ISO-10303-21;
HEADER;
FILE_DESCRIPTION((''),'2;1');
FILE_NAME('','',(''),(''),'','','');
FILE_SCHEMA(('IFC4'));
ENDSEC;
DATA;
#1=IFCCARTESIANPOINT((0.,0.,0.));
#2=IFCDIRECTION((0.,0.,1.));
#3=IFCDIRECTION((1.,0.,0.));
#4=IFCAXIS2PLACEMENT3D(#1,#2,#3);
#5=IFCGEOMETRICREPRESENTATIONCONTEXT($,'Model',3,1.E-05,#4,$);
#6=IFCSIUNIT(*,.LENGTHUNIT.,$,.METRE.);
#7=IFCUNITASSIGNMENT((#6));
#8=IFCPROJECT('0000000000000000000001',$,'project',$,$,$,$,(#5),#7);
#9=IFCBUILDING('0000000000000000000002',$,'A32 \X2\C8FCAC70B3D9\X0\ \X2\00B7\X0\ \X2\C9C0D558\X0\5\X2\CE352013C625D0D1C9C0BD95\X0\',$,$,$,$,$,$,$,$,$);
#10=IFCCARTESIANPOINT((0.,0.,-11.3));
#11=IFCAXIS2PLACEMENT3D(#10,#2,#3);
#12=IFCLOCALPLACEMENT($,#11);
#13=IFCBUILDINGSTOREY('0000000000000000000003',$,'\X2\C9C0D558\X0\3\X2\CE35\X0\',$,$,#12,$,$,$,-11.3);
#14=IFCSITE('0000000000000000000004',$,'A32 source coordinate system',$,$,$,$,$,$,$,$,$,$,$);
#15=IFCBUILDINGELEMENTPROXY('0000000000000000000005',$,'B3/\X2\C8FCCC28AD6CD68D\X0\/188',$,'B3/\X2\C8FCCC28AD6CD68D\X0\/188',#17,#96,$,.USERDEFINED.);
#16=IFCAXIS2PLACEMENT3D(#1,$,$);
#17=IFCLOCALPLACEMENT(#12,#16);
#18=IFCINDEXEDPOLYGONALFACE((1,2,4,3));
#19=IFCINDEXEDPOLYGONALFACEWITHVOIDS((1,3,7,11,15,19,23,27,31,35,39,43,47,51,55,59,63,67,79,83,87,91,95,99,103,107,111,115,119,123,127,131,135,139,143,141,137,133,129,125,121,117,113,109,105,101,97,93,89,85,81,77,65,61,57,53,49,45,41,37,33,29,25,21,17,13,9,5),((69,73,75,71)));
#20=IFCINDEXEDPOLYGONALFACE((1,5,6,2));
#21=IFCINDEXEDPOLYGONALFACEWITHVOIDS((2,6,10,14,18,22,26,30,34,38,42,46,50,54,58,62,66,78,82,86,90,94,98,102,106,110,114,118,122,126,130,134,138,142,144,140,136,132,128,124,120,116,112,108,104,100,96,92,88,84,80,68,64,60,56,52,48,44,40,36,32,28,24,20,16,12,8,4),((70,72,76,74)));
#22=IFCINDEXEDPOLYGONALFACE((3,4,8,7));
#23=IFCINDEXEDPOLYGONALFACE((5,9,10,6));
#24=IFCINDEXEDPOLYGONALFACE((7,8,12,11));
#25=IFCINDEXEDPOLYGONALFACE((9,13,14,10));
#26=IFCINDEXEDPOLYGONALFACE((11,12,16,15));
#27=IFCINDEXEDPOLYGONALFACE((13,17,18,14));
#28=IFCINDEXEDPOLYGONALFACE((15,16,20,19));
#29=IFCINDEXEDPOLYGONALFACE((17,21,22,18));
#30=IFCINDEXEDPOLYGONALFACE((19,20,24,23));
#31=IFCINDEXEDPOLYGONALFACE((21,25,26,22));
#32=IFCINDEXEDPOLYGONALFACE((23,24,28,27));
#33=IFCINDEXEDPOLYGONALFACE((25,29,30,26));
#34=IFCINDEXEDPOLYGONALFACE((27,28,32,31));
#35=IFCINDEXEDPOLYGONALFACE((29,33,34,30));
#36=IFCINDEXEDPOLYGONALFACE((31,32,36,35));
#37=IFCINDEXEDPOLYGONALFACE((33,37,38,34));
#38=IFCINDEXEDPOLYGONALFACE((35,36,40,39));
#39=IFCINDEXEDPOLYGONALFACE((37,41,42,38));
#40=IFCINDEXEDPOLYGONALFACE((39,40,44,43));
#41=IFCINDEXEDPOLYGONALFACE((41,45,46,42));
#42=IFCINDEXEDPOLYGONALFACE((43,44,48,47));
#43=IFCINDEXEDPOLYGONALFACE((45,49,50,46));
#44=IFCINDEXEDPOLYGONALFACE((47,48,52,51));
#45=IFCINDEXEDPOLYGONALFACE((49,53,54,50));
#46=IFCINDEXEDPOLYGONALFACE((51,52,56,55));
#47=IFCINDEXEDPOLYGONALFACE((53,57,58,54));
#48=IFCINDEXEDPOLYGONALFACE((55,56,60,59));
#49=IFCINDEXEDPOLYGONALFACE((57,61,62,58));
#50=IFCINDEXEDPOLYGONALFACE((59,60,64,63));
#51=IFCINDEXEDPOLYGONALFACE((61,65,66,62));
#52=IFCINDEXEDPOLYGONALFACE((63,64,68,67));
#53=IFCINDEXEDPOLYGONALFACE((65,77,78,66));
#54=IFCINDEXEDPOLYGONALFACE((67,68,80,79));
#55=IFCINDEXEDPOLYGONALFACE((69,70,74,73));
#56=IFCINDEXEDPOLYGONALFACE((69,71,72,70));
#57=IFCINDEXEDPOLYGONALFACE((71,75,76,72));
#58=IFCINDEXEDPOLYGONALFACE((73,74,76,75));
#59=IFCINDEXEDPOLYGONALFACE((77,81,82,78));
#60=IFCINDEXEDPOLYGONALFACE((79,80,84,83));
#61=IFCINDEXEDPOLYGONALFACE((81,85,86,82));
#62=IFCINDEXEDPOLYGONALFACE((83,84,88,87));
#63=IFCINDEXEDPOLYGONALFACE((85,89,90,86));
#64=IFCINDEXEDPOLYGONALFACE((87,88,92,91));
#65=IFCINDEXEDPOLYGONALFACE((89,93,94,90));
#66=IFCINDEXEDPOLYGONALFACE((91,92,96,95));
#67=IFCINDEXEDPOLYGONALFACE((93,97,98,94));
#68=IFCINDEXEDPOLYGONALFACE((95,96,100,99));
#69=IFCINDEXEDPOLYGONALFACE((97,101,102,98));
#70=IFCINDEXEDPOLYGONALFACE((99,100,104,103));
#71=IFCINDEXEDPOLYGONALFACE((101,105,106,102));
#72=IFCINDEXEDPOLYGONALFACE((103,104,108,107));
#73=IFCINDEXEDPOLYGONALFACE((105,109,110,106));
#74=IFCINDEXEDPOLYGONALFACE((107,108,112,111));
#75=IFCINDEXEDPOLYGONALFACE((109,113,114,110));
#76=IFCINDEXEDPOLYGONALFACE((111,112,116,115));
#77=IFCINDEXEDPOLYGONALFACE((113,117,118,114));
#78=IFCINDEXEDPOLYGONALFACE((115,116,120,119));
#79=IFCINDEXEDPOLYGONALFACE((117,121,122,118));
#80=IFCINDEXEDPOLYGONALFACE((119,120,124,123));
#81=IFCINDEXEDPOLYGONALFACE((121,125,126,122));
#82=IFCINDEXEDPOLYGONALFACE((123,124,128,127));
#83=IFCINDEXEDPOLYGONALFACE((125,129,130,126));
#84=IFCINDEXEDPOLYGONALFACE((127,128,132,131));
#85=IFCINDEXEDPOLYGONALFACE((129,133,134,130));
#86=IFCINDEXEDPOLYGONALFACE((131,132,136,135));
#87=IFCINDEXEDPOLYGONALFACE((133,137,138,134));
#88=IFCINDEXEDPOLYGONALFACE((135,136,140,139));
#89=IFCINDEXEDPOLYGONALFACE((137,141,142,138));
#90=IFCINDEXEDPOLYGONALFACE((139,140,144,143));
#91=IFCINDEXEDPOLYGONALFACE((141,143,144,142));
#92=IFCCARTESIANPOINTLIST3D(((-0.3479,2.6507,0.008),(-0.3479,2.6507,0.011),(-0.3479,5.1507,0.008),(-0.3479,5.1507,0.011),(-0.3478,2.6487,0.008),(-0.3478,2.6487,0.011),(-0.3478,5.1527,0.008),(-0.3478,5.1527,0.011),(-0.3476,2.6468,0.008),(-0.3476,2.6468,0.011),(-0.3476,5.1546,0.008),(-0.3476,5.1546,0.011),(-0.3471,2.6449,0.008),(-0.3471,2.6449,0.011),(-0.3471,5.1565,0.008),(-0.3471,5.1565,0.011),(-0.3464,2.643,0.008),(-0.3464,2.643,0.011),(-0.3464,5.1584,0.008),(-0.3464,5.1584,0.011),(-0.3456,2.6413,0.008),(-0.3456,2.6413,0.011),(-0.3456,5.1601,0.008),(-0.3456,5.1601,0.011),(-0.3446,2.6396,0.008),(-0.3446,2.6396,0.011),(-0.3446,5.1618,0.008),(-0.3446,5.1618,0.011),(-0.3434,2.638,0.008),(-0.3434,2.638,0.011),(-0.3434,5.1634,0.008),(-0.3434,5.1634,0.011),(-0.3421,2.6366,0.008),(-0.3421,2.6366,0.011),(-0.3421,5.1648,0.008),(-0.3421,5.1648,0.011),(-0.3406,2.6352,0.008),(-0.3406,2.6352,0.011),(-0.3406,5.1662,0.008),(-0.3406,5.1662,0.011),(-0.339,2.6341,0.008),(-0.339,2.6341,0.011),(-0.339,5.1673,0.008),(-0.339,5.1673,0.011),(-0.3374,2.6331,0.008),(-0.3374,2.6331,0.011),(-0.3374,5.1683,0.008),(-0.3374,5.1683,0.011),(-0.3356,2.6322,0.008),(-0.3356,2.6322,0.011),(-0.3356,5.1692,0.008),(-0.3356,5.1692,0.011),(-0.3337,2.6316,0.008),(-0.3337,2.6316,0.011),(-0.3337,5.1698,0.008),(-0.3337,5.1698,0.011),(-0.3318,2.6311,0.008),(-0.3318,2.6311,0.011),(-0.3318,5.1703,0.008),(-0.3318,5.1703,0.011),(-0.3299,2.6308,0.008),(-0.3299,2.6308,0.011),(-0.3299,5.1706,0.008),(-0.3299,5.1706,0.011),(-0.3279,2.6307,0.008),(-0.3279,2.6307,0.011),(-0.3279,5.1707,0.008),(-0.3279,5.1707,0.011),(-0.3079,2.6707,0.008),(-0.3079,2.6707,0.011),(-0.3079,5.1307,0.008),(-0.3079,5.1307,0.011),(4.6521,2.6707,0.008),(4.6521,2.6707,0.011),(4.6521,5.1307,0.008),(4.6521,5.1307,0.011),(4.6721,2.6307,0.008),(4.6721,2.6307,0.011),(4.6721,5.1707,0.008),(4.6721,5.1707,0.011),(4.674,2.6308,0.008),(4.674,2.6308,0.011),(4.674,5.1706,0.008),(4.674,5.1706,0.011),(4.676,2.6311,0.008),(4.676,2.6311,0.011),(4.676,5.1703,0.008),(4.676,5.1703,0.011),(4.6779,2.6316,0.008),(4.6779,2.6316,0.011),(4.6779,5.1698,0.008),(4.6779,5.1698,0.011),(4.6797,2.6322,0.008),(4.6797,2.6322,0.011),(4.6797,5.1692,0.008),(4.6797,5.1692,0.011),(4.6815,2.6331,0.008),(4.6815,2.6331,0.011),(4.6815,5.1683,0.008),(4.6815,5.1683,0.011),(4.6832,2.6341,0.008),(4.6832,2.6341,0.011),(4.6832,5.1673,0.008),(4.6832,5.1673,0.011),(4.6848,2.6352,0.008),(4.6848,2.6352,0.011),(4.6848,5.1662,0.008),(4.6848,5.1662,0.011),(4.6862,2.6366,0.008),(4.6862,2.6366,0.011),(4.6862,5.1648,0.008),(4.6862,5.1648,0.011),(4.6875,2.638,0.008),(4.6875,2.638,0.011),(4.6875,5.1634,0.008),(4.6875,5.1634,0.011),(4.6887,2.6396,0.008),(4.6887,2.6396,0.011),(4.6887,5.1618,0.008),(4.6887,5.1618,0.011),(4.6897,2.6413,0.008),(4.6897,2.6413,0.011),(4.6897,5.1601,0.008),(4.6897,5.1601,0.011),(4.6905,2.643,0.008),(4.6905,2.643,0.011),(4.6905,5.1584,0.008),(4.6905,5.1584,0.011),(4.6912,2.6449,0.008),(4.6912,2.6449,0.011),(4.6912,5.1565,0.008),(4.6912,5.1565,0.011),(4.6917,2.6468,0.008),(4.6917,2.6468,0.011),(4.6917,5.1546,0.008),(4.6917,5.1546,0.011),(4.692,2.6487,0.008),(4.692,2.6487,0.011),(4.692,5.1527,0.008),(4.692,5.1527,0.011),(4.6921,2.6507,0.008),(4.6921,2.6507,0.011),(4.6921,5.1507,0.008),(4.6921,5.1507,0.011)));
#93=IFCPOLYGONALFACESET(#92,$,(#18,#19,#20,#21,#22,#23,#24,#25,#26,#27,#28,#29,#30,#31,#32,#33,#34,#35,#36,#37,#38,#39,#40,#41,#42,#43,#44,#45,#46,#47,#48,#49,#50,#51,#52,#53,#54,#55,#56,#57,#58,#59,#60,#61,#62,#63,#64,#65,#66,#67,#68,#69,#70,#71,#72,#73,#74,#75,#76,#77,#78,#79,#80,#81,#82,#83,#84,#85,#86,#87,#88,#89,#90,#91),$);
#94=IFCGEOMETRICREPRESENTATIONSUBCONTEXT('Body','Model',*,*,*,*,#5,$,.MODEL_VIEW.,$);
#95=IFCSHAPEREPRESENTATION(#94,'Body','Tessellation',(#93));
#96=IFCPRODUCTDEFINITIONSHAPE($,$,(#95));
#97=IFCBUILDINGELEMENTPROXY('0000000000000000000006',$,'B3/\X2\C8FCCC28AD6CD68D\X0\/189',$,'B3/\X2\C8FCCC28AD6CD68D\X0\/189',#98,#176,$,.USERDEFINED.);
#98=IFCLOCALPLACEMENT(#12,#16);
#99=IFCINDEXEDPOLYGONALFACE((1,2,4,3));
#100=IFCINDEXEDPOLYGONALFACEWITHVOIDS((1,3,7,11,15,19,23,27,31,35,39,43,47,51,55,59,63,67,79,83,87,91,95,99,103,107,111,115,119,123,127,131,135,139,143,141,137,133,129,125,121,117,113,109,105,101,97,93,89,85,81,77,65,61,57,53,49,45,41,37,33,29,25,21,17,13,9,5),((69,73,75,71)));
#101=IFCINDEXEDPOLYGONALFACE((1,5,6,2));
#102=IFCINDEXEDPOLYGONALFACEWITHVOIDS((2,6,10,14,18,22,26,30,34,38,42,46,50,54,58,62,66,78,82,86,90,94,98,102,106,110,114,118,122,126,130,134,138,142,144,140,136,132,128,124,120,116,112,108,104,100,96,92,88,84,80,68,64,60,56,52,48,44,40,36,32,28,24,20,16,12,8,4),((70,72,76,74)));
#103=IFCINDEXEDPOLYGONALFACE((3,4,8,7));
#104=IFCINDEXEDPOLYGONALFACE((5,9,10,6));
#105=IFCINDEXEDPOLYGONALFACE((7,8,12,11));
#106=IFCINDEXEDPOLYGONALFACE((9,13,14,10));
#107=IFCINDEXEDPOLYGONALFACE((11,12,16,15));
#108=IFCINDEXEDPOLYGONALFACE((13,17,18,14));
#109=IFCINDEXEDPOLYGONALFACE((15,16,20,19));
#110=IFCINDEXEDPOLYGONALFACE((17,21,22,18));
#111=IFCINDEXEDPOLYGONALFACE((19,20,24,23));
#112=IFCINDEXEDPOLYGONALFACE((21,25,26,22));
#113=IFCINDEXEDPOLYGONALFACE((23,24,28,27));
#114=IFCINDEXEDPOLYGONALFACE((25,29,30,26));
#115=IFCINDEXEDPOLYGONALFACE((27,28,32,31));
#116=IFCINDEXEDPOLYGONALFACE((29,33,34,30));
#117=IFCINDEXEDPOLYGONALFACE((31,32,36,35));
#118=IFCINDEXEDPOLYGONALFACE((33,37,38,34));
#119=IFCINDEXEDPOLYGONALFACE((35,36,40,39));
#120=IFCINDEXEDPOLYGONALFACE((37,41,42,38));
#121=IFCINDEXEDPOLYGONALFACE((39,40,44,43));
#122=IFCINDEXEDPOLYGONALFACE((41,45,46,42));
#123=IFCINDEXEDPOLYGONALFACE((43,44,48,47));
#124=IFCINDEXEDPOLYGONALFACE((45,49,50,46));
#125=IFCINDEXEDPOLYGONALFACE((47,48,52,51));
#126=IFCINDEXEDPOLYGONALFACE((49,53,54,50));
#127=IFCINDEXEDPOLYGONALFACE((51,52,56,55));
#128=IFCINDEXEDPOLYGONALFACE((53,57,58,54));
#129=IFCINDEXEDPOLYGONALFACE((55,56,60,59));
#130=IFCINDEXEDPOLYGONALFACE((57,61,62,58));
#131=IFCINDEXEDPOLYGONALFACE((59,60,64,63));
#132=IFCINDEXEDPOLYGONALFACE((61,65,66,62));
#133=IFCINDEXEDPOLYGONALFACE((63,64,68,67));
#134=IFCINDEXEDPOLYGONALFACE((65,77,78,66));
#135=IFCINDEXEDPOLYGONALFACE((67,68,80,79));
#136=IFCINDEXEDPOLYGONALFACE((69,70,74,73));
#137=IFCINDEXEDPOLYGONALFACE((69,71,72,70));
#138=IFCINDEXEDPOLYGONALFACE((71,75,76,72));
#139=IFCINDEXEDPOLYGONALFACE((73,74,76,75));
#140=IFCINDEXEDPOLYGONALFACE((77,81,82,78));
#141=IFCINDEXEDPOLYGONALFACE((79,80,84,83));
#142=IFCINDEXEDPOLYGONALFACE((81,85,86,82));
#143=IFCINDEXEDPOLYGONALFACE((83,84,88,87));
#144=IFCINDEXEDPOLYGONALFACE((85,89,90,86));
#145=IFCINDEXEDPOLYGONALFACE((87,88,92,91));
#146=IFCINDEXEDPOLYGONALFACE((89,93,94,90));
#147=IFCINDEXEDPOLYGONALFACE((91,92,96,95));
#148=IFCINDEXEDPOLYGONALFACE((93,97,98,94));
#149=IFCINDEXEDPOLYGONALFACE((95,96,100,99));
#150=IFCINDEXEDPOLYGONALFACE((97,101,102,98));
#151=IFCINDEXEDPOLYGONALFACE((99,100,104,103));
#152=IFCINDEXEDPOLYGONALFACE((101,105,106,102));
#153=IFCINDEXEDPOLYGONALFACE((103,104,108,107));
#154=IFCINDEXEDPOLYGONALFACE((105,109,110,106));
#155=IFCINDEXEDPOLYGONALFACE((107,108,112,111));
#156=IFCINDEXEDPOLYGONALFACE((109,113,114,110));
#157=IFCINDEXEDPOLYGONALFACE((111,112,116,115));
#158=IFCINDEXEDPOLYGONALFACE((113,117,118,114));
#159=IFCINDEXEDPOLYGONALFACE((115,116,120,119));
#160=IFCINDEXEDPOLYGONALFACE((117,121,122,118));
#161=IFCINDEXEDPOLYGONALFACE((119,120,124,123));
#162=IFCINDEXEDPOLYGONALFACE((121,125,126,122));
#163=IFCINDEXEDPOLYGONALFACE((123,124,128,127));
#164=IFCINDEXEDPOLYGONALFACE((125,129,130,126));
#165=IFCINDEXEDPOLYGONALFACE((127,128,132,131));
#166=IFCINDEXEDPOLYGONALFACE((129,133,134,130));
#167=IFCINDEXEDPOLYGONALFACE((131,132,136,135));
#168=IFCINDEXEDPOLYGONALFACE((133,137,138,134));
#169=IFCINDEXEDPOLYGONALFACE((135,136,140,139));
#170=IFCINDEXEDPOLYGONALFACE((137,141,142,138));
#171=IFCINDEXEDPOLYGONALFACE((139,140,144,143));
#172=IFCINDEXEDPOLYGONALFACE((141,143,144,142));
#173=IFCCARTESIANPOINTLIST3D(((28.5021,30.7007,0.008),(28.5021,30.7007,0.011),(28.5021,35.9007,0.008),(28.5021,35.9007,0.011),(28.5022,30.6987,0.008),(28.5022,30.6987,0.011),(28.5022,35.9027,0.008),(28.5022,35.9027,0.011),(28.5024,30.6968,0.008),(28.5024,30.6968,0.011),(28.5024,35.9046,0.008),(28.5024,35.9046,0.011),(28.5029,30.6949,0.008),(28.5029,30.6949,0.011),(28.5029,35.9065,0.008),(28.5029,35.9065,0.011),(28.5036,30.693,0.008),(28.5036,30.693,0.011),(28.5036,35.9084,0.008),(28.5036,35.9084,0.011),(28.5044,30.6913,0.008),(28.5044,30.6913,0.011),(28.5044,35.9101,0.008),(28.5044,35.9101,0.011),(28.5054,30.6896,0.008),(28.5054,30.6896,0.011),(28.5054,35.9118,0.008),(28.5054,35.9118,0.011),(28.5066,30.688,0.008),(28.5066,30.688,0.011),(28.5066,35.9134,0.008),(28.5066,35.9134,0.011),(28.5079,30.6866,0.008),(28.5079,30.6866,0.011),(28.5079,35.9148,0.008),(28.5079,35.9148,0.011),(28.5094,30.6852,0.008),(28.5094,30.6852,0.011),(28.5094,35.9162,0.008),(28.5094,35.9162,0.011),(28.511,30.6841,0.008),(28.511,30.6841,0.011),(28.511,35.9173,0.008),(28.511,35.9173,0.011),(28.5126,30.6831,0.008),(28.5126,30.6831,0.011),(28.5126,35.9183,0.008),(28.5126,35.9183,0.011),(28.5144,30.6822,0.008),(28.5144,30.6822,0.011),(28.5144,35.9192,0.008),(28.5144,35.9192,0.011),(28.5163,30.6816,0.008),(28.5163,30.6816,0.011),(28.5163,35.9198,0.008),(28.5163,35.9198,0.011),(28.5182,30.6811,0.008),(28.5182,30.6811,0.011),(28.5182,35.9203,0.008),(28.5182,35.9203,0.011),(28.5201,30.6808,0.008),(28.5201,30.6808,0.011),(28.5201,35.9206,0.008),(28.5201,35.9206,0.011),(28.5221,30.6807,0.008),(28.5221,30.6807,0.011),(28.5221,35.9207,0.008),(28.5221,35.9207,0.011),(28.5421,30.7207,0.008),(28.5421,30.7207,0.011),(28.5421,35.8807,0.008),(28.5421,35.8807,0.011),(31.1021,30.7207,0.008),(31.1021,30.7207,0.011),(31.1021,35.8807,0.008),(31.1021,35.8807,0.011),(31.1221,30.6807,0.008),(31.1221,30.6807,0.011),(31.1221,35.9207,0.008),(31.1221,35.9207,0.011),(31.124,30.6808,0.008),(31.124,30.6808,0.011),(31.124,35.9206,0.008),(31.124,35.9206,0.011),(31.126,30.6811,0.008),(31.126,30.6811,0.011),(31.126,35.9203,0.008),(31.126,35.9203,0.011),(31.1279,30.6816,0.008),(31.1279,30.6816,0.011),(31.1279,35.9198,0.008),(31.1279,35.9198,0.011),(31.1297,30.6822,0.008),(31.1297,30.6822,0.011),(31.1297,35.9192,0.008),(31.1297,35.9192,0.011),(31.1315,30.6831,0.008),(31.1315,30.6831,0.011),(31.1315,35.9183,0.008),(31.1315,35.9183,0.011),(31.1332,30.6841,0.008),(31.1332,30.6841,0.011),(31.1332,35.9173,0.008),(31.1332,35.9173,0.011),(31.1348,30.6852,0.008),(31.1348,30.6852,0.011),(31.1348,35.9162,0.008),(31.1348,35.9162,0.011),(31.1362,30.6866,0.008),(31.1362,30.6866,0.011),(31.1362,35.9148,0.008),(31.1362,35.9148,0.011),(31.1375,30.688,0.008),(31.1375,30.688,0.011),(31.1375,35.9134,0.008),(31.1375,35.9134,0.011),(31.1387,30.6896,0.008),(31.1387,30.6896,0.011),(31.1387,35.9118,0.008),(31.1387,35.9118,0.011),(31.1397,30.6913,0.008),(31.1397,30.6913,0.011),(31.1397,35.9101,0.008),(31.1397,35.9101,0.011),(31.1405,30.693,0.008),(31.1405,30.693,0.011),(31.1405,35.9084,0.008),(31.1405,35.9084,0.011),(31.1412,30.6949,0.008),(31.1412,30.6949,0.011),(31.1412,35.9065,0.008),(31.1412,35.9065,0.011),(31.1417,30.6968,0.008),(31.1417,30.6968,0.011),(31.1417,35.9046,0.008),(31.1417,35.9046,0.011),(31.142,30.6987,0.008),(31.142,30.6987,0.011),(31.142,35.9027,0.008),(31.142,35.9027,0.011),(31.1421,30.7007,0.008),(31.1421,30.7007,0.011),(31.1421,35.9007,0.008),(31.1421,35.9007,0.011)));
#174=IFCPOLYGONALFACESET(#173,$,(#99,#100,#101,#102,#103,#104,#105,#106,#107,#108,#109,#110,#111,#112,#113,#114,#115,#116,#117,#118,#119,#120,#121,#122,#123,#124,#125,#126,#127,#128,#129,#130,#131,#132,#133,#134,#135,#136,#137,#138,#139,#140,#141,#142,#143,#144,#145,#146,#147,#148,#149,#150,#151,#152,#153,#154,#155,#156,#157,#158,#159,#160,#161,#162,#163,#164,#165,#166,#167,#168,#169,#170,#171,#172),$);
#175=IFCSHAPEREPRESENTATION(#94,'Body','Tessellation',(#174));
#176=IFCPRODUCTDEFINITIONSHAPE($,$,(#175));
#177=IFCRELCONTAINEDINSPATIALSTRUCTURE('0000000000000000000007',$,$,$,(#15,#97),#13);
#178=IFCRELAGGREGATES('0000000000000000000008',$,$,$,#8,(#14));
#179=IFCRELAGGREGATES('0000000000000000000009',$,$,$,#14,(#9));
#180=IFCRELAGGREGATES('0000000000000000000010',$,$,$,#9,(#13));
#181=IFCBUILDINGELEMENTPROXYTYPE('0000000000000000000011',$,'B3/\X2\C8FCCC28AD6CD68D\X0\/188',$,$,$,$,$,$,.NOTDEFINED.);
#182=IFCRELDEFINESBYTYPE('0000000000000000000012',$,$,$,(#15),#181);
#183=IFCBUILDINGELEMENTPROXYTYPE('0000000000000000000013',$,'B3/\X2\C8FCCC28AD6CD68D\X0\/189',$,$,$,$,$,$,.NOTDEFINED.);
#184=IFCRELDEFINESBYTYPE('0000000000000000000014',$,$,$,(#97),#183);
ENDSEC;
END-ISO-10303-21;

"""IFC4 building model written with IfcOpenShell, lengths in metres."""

from ifc_helpers import new_model, si_unit, frame, origin, origin_with_axes, place, context, subcontext, project, spatial, polyline, outline, extrude, source, transform, mapped, type_object, type_shapes, element, save


model = new_model("IFC4")

# Units and contexts
model_context = context("Model", 3, precision=1e-05, world=origin_with_axes())
body_context = subcontext(model_context, "Body", "Model", "MODEL_VIEW")
ifc_project = project(units=[si_unit("LENGTHUNIT", "METRE")], contexts=[model_context])

# Site, building, storey
site = spatial("IfcSite", under=ifc_project, Name="A32 source coordinate system")
building = spatial("IfcBuilding", under=site, Name="A32 주거동 · 지하5층–옥탑지붕")
storey_placement = place(None, frame((0.0, 0.0, -11.3), z_axis=(0.0, 0.0, 1.0), x_axis=(1.0, 0.0, 0.0)))
storey = spatial("IfcBuildingStorey", under=building, at=storey_placement, Name="지하3층", Elevation=-11.3)

# Building element proxies
building_element_proxy_type_1 = type_object("IfcBuildingElementProxyType", Name="B3/주차구획/188", PredefinedType="NOTDEFINED")
shared_shape_1 = source(origin(), body_context, "Body", "SweptSolid", [
    extrude(outline(polyline([(-0.3279, 2.6307), (-0.3299, 2.6308), (-0.3318, 2.6311), (-0.3337, 2.6316), (-0.3356, 2.6322), (-0.3374, 2.6331), (-0.339, 2.6341), (-0.3406, 2.6352), (-0.3421, 2.6366), (-0.3434, 2.638), (-0.3446, 2.6396), (-0.3456, 2.6413), (-0.3464, 2.643), (-0.3471, 2.6449), (-0.3476, 2.6468), (-0.3478, 2.6487), (-0.3479, 2.6507), (-0.3479, 5.1507), (-0.3478, 5.1527), (-0.3476, 5.1546), (-0.3471, 5.1565), (-0.3464, 5.1584), (-0.3456, 5.1601), (-0.3446, 5.1618), (-0.3434, 5.1634), (-0.3421, 5.1648), (-0.3406, 5.1662), (-0.339, 5.1673), (-0.3374, 5.1683), (-0.3356, 5.1692), (-0.3337, 5.1698), (-0.3318, 5.1703), (-0.3299, 5.1706), (-0.3279, 5.1707), (4.6721, 5.1707), (4.674, 5.1706), (4.676, 5.1703), (4.6779, 5.1698), (4.6797, 5.1692), (4.6815, 5.1683), (4.6832, 5.1673), (4.6848, 5.1662), (4.6862, 5.1648), (4.6875, 5.1634), (4.6887, 5.1618), (4.6897, 5.1601), (4.6905, 5.1584), (4.6912, 5.1565), (4.6917, 5.1546), (4.692, 5.1527), (4.6921, 5.1507), (4.6921, 2.6507), (4.692, 2.6487), (4.6917, 2.6468), (4.6912, 2.6449), (4.6905, 2.643), (4.6897, 2.6413), (4.6887, 2.6396), (4.6875, 2.638), (4.6862, 2.6366), (4.6848, 2.6352), (4.6832, 2.6341), (4.6815, 2.6331), (4.6797, 2.6322), (4.6779, 2.6316), (4.676, 2.6311), (4.674, 2.6308), (4.6721, 2.6307), (-0.3279, 2.6307)]), holes=[polyline([(-0.3079, 2.6707), (4.6521, 2.6707), (4.6521, 5.1307), (-0.3079, 5.1307), (-0.3079, 2.6707)])]), frame((0.0, 0.0, 0.008)), (0.0, 0.0, 1.0), 0.003),
])
type_shapes(building_element_proxy_type_1, [shared_shape_1])
proxy_1_placement = place(storey_placement, origin_with_axes())
element("IfcBuildingElementProxy", 1, at=proxy_1_placement, inside=storey, type_object=building_element_proxy_type_1, Name="B3/주차구획/188", ObjectType="B3/주차구획/188", PredefinedType="USERDEFINED", context=body_context, shape_type="MappedRepresentation", body=[
    mapped(shared_shape_1, transform((0.0, 0.0, 0.0), scale=1.0)),
])
building_element_proxy_type_2 = type_object("IfcBuildingElementProxyType", Name="B3/주차구획/189", PredefinedType="NOTDEFINED")
shared_shape_2 = source(origin(), body_context, "Body", "SweptSolid", [
    extrude(outline(polyline([(28.5021, 35.9007), (28.5022, 35.9027), (28.5024, 35.9046), (28.5029, 35.9065), (28.5036, 35.9084), (28.5044, 35.9101), (28.5054, 35.9118), (28.5066, 35.9134), (28.5079, 35.9148), (28.5094, 35.9162), (28.511, 35.9173), (28.5126, 35.9183), (28.5144, 35.9192), (28.5163, 35.9198), (28.5182, 35.9203), (28.5201, 35.9206), (28.5221, 35.9207), (31.1221, 35.9207), (31.124, 35.9206), (31.126, 35.9203), (31.1279, 35.9198), (31.1297, 35.9192), (31.1315, 35.9183), (31.1332, 35.9173), (31.1348, 35.9162), (31.1362, 35.9148), (31.1375, 35.9134), (31.1387, 35.9118), (31.1397, 35.9101), (31.1405, 35.9084), (31.1412, 35.9065), (31.1417, 35.9046), (31.142, 35.9027), (31.1421, 35.9007), (31.1421, 30.7007), (31.142, 30.6987), (31.1417, 30.6968), (31.1412, 30.6949), (31.1405, 30.693), (31.1397, 30.6913), (31.1387, 30.6896), (31.1375, 30.688), (31.1362, 30.6866), (31.1348, 30.6852), (31.1332, 30.6841), (31.1315, 30.6831), (31.1297, 30.6822), (31.1279, 30.6816), (31.126, 30.6811), (31.124, 30.6808), (31.1221, 30.6807), (28.5221, 30.6807), (28.5201, 30.6808), (28.5182, 30.6811), (28.5163, 30.6816), (28.5144, 30.6822), (28.5126, 30.6831), (28.511, 30.6841), (28.5094, 30.6852), (28.5079, 30.6866), (28.5066, 30.688), (28.5054, 30.6896), (28.5044, 30.6913), (28.5036, 30.693), (28.5029, 30.6949), (28.5024, 30.6968), (28.5022, 30.6987), (28.5021, 30.7007), (28.5021, 35.9007)]), holes=[polyline([(28.5421, 35.8807), (28.5421, 30.7207), (31.1021, 30.7207), (31.1021, 35.8807), (28.5421, 35.8807)])]), frame((0.0, 0.0, 0.008)), (0.0, 0.0, 1.0), 0.003),
])
type_shapes(building_element_proxy_type_2, [shared_shape_2])
proxy_2_placement = place(storey_placement, origin_with_axes())
element("IfcBuildingElementProxy", 2, at=proxy_2_placement, inside=storey, type_object=building_element_proxy_type_2, Name="B3/주차구획/189", ObjectType="B3/주차구획/189", PredefinedType="USERDEFINED", context=body_context, shape_type="MappedRepresentation", body=[
    mapped(shared_shape_2, transform((0.0, 0.0, 0.0), scale=1.0)),
])

save(model, "model.ifc")
